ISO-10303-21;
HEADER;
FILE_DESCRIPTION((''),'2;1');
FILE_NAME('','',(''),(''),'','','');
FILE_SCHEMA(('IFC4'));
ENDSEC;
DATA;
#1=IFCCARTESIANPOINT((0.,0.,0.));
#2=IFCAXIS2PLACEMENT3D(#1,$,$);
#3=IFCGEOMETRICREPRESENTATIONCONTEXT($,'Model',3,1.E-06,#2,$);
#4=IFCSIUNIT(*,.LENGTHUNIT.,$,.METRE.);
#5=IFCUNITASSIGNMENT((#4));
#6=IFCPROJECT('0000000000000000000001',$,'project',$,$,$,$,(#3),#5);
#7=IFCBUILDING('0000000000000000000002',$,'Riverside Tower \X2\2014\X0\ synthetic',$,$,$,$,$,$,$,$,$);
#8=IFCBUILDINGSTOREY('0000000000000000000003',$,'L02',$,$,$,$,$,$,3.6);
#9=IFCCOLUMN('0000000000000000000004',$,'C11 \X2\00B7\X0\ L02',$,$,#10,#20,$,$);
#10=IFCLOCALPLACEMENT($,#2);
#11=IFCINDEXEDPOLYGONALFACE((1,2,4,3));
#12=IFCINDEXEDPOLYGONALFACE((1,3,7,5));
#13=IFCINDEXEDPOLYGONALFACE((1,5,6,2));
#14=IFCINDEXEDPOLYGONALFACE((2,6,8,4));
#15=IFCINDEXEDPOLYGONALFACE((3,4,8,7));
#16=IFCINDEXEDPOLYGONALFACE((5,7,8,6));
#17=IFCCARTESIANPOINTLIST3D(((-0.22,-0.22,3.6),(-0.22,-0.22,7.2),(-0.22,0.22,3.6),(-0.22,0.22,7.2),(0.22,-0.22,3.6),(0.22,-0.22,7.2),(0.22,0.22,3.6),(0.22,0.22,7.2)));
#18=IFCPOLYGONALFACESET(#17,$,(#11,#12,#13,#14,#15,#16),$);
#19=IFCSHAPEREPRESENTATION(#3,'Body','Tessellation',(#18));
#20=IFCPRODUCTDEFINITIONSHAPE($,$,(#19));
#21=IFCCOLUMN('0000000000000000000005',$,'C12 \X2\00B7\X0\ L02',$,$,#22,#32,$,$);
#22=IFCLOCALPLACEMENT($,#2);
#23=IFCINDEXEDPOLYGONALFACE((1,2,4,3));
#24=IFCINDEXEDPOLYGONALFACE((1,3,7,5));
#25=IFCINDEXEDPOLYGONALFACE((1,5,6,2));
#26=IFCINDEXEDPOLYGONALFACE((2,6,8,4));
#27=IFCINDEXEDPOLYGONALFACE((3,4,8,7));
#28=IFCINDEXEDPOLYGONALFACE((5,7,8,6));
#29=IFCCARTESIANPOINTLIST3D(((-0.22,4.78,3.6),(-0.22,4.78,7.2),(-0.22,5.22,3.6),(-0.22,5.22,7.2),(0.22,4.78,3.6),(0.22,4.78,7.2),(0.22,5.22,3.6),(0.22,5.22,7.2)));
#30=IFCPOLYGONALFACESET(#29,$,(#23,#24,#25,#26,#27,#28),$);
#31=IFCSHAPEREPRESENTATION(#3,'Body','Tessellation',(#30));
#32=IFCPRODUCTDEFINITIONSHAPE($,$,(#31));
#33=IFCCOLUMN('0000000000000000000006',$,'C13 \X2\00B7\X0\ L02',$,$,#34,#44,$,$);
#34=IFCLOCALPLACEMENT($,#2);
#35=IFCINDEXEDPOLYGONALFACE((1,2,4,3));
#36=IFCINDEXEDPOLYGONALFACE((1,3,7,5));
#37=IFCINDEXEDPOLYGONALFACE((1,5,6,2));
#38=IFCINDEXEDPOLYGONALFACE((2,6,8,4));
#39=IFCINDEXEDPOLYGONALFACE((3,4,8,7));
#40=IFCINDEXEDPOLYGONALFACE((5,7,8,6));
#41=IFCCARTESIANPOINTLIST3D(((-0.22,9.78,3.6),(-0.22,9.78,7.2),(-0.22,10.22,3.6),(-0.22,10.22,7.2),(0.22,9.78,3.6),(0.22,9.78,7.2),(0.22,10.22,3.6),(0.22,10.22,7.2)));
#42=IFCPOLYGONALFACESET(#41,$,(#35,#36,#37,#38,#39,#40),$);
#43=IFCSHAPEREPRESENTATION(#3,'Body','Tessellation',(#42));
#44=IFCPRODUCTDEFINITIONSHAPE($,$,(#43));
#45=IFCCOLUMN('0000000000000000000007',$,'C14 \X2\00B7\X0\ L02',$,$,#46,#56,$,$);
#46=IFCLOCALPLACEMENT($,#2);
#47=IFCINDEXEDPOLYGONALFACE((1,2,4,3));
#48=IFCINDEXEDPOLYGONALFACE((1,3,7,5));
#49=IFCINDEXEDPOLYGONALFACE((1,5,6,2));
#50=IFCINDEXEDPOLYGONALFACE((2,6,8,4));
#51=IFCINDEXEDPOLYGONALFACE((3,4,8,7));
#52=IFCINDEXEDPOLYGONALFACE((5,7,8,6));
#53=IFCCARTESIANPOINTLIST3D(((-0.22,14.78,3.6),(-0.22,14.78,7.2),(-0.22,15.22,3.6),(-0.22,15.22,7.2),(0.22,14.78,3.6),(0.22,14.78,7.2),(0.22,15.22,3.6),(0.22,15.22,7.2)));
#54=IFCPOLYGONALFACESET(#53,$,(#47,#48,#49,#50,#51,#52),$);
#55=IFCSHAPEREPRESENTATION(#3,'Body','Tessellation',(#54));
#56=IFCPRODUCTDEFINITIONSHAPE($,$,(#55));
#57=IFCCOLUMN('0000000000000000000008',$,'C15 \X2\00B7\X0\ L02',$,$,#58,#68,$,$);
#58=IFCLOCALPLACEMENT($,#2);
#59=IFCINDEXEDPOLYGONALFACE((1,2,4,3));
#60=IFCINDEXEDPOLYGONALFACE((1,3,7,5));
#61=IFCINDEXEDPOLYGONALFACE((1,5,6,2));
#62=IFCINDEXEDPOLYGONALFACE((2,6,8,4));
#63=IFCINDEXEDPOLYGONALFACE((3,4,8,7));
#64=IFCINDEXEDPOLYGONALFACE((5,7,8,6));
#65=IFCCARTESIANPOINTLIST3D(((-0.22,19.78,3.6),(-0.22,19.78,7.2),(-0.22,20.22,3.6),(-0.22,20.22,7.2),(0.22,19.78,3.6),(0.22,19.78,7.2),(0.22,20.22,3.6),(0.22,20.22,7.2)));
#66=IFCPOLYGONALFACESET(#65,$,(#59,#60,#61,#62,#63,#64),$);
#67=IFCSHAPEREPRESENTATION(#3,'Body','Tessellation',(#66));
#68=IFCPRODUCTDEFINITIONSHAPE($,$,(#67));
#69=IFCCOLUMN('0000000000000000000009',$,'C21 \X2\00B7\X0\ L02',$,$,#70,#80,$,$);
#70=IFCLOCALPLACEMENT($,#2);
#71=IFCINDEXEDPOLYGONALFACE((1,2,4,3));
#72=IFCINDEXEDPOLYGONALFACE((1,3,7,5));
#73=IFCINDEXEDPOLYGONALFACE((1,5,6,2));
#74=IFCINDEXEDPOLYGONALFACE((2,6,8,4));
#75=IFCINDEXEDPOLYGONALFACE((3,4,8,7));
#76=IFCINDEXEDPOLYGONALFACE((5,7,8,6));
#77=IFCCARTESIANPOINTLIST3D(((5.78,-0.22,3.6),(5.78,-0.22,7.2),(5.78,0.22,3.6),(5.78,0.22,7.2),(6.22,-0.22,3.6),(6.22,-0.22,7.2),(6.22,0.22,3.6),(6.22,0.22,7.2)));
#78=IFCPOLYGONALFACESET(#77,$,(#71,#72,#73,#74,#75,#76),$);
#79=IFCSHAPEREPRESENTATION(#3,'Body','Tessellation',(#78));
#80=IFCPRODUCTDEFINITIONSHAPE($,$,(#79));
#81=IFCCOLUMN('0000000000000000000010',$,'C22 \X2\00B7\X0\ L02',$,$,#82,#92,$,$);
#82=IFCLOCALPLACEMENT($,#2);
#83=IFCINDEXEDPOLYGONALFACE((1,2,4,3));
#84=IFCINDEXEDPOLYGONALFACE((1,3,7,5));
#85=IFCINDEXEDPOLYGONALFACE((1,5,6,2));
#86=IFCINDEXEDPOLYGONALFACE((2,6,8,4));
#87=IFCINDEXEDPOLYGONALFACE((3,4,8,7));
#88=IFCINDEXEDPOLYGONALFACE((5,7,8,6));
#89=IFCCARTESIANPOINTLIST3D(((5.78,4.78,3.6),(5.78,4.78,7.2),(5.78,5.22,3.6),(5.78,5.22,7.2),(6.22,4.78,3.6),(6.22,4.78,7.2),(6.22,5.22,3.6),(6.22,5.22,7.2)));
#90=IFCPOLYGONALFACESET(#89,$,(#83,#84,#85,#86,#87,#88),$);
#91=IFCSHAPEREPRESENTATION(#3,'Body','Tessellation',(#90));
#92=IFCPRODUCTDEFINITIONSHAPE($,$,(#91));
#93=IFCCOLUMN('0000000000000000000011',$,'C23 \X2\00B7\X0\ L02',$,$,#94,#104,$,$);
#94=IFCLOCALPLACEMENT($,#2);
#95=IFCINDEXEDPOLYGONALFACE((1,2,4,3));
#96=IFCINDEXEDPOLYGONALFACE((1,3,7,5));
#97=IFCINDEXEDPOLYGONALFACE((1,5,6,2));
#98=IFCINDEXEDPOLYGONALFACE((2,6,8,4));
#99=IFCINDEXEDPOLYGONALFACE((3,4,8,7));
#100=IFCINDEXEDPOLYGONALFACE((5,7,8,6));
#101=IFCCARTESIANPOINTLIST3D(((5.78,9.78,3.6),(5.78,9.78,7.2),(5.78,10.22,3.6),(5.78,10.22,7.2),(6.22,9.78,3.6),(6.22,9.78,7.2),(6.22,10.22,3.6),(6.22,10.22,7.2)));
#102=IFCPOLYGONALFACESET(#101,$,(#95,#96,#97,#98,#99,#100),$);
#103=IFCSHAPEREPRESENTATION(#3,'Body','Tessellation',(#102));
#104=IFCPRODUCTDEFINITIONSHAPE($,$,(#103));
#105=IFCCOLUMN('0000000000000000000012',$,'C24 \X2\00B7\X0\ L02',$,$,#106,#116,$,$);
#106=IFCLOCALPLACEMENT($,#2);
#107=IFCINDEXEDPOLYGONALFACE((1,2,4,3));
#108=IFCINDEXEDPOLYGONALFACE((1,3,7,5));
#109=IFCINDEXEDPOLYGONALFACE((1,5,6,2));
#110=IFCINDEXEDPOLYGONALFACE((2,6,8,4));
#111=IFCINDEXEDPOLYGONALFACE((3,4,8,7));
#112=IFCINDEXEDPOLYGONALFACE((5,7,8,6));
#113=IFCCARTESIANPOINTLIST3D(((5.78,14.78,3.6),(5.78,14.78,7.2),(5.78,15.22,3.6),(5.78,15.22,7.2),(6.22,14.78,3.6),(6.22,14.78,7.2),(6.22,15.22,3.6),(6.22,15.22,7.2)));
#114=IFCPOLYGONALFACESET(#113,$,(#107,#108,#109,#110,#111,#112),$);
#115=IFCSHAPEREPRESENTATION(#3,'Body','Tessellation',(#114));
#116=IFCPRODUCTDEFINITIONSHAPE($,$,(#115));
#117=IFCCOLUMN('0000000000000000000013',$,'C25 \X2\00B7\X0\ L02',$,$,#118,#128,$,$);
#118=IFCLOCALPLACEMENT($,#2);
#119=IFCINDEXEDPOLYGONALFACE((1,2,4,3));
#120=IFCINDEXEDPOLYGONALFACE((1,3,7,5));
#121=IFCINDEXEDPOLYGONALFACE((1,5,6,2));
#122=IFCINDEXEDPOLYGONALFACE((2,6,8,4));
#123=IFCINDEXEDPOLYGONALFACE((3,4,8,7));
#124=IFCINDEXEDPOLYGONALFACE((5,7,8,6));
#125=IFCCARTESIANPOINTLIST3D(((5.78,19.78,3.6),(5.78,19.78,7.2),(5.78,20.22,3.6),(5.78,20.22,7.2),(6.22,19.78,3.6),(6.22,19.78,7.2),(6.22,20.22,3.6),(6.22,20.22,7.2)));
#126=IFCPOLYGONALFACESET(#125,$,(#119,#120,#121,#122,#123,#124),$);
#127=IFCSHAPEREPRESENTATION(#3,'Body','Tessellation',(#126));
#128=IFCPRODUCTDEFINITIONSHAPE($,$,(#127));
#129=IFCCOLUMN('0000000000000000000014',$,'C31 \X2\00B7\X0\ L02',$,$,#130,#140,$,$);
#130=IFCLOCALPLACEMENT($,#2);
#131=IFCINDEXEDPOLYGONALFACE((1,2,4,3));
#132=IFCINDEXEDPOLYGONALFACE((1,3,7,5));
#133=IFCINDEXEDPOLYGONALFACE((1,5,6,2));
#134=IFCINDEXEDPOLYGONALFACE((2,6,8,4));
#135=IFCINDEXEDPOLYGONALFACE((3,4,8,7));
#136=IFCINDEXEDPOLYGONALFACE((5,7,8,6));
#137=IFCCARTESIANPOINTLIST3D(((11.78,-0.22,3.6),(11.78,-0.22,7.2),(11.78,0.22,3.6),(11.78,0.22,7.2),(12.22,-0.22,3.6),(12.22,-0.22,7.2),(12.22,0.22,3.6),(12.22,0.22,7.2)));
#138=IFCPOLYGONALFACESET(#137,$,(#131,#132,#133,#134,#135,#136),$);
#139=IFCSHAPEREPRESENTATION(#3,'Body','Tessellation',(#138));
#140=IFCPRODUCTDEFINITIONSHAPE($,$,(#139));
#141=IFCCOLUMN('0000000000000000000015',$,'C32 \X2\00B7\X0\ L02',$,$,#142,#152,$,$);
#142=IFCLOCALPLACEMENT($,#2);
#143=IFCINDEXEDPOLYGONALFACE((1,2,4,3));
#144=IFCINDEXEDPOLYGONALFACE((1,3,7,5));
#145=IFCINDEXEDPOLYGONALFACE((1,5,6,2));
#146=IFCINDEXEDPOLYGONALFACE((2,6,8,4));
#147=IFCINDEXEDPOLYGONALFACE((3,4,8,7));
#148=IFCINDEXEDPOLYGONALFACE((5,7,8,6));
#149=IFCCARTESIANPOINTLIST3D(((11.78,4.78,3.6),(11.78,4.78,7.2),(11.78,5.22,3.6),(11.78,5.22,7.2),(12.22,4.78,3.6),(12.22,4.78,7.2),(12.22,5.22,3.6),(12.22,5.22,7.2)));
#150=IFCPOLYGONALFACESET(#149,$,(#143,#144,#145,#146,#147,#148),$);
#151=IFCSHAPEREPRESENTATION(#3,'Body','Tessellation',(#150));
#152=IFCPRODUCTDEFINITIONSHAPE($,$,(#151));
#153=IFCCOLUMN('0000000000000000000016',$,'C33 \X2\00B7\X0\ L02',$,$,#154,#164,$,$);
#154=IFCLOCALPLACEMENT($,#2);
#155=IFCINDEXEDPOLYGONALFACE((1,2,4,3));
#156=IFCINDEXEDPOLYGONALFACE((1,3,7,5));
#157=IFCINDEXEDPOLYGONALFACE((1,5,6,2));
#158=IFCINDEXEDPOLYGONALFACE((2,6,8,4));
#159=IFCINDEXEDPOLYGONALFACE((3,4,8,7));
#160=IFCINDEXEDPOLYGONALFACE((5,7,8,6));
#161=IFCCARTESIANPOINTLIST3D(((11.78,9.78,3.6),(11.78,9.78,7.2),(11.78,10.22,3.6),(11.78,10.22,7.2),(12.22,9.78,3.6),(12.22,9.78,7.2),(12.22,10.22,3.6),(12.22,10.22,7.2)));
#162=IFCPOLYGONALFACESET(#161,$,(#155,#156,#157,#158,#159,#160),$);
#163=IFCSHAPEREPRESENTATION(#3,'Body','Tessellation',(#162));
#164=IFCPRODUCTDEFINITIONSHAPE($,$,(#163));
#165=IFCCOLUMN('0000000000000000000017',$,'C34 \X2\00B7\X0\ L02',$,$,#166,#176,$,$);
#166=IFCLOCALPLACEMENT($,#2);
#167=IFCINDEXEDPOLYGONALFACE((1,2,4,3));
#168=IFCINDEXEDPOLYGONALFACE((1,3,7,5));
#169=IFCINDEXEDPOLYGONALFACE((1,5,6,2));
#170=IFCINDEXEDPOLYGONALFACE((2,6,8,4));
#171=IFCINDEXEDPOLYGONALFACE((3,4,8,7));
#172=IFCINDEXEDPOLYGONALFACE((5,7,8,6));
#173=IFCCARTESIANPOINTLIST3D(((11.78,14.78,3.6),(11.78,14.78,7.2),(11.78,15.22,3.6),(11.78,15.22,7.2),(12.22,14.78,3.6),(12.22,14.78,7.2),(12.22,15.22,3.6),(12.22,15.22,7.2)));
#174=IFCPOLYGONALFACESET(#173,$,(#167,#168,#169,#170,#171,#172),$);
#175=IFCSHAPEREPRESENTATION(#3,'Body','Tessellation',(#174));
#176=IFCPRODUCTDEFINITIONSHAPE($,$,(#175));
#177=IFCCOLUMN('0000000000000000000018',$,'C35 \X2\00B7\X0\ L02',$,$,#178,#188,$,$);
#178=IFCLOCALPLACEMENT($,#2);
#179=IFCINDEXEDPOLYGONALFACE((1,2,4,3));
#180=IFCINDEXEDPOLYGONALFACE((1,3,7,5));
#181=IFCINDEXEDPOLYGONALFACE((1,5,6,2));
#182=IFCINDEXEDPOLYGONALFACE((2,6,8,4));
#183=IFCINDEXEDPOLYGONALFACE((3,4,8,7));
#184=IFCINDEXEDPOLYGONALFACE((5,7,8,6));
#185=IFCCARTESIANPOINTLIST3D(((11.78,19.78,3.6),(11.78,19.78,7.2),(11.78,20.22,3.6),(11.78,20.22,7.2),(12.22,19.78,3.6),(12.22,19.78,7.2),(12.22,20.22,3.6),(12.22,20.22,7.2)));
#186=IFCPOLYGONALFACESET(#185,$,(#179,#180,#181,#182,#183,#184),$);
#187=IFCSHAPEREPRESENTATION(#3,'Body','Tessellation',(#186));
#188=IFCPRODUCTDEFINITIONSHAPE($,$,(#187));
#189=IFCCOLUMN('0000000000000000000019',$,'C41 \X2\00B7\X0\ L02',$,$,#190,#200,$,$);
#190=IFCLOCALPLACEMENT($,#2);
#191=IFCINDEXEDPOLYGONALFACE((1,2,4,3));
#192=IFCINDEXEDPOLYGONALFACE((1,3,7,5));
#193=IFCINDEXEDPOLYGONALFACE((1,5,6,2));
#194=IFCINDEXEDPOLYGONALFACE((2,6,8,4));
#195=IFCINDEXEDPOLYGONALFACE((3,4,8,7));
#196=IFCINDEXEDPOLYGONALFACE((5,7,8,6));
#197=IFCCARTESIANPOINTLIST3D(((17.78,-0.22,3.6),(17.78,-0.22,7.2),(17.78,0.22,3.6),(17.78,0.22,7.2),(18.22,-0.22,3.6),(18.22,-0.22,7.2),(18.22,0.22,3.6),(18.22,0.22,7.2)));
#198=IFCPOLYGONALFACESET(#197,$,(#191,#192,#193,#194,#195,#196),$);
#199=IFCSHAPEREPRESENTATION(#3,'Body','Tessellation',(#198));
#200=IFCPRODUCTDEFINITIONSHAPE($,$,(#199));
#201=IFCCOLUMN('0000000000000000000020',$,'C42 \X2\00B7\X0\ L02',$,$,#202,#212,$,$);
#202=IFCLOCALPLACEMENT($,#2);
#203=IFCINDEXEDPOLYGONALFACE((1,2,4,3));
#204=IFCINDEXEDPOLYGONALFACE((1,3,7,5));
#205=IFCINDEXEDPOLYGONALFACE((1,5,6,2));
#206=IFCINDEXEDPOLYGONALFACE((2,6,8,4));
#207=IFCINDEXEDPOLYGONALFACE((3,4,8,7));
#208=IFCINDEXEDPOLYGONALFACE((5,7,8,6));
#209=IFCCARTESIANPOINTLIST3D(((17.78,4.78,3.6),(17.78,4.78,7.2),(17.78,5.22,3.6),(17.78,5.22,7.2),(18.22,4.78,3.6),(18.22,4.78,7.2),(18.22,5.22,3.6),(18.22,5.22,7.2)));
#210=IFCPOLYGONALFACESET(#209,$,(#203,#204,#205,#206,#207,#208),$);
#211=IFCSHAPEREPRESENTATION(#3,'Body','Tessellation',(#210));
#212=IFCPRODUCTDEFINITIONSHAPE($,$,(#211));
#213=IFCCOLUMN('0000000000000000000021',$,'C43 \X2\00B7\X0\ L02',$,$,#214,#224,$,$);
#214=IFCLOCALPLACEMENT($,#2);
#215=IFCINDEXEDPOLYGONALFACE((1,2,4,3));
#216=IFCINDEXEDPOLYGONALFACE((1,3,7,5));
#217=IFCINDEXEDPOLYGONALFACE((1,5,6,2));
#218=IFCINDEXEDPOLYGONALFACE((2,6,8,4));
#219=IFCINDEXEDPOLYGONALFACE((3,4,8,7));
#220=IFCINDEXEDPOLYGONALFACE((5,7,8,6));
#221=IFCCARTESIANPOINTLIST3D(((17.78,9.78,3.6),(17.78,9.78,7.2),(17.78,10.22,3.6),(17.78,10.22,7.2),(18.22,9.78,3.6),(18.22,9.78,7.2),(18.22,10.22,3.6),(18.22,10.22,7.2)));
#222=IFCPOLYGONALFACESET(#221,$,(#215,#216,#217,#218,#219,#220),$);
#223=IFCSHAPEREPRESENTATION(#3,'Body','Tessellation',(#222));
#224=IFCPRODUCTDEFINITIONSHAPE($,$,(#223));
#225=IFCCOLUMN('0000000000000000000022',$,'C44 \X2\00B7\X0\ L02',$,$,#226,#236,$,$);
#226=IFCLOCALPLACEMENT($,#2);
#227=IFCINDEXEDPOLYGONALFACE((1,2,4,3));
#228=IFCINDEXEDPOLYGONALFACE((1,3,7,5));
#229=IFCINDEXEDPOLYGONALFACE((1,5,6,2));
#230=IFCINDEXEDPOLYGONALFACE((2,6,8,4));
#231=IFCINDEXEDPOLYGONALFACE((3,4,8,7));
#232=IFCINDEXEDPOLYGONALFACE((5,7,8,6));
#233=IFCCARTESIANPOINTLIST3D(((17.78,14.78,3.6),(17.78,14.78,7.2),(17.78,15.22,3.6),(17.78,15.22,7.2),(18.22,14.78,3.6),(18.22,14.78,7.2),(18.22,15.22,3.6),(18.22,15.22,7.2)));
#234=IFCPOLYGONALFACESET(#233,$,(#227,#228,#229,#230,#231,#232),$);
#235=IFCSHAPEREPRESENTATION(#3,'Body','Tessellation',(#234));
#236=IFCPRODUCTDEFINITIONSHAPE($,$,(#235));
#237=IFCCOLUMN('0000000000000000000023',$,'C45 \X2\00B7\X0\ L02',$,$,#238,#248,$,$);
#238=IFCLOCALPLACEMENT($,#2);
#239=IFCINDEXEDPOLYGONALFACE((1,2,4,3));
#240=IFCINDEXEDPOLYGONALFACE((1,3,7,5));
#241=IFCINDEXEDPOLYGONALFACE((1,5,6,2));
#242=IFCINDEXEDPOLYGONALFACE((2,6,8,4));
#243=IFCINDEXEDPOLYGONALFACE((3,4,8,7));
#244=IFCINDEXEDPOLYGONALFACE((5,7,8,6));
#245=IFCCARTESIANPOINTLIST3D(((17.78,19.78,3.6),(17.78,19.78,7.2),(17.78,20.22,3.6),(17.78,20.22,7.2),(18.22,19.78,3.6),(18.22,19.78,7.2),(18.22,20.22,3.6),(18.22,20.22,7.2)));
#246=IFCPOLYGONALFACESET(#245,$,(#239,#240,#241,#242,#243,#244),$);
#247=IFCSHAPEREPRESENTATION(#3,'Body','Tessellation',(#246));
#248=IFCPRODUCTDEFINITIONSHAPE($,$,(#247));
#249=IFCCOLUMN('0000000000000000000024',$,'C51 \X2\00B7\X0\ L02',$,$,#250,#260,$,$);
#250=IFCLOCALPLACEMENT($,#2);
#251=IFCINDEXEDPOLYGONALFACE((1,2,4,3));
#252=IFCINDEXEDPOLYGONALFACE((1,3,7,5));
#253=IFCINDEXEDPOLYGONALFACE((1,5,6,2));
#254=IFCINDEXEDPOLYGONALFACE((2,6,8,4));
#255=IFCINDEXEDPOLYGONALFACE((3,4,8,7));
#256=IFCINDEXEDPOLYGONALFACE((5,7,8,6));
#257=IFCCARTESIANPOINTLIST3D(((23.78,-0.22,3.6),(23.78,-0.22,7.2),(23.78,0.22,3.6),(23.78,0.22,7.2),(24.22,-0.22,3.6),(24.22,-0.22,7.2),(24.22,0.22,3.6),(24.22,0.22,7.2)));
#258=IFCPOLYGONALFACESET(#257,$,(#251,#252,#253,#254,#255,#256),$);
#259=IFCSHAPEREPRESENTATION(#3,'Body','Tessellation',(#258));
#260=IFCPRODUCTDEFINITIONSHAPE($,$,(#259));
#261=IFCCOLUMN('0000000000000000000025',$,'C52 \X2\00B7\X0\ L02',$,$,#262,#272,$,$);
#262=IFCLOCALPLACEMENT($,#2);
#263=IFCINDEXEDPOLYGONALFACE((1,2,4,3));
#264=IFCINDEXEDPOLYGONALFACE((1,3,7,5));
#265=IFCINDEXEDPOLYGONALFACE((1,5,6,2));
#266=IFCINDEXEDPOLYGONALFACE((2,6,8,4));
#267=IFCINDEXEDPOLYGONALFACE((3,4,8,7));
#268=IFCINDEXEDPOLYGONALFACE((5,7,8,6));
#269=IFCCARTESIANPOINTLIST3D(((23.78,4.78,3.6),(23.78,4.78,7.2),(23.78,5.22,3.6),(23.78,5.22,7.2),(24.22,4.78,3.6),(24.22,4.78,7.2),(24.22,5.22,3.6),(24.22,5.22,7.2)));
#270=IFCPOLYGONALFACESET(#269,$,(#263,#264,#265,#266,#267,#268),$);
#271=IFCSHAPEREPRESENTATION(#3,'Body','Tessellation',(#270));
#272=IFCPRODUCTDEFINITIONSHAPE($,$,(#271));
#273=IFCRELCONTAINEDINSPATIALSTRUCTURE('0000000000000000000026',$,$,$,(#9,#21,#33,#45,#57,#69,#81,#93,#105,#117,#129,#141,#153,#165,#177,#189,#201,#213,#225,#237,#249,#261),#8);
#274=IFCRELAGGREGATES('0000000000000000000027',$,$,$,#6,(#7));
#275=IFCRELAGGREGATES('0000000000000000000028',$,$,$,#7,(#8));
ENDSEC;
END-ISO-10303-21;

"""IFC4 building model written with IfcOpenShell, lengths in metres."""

from ifc_helpers import new_model, si_unit, frame, origin, place, context, project, spatial, rectangle, extrude, element, save


model = new_model("IFC4")

# Units and contexts
model_context = context("Model", 3, precision=1e-06, world=origin())
ifc_project = project(units=[si_unit("LENGTHUNIT", "METRE")], contexts=[model_context])

# Building, storey
building = spatial("IfcBuilding", under=ifc_project, Name="Riverside Tower — synthetic")
storey = spatial("IfcBuildingStorey", under=building, Name="L02", Elevation=3.6)

# Columns
for number, where, name in (
    (1, (0.0, 0.0, 3.6), "C11 · L02"),
    (2, (0.0, 5.0, 3.6), "C12 · L02"),
    (3, (0.0, 10.0, 3.6), "C13 · L02"),
    (4, (0.0, 15.0, 3.6), "C14 · L02"),
    (5, (0.0, 20.0, 3.6), "C15 · L02"),
    (6, (6.0, 0.0, 3.6), "C21 · L02"),
    (7, (6.0, 5.0, 3.6), "C22 · L02"),
    (8, (6.0, 10.0, 3.6), "C23 · L02"),
    (9, (6.0, 15.0, 3.6), "C24 · L02"),
    (10, (6.0, 20.0, 3.6), "C25 · L02"),
    (11, (12.0, 0.0, 3.6), "C31 · L02"),
    (12, (12.0, 5.0, 3.6), "C32 · L02"),
    (13, (12.0, 10.0, 3.6), "C33 · L02"),
    (14, (12.0, 15.0, 3.6), "C34 · L02"),
    (15, (12.0, 20.0, 3.6), "C35 · L02"),
    (16, (18.0, 0.0, 3.6), "C41 · L02"),
    (17, (18.0, 5.0, 3.6), "C42 · L02"),
    (18, (18.0, 10.0, 3.6), "C43 · L02"),
    (19, (18.0, 15.0, 3.6), "C44 · L02"),
    (20, (18.0, 20.0, 3.6), "C45 · L02"),
    (21, (24.0, 0.0, 3.6), "C51 · L02"),
    (22, (24.0, 5.0, 3.6), "C52 · L02"),
):
    element("IfcColumn", number, at=place(None, frame(where)), inside=storey, Name=name, context=model_context, shape_type="SweptSolid", body=[
        extrude(rectangle(XDim=0.44, YDim=0.44), origin(), (0.0, 0.0, 1.0), 3.6),
    ])

save(model, "model.ifc")
